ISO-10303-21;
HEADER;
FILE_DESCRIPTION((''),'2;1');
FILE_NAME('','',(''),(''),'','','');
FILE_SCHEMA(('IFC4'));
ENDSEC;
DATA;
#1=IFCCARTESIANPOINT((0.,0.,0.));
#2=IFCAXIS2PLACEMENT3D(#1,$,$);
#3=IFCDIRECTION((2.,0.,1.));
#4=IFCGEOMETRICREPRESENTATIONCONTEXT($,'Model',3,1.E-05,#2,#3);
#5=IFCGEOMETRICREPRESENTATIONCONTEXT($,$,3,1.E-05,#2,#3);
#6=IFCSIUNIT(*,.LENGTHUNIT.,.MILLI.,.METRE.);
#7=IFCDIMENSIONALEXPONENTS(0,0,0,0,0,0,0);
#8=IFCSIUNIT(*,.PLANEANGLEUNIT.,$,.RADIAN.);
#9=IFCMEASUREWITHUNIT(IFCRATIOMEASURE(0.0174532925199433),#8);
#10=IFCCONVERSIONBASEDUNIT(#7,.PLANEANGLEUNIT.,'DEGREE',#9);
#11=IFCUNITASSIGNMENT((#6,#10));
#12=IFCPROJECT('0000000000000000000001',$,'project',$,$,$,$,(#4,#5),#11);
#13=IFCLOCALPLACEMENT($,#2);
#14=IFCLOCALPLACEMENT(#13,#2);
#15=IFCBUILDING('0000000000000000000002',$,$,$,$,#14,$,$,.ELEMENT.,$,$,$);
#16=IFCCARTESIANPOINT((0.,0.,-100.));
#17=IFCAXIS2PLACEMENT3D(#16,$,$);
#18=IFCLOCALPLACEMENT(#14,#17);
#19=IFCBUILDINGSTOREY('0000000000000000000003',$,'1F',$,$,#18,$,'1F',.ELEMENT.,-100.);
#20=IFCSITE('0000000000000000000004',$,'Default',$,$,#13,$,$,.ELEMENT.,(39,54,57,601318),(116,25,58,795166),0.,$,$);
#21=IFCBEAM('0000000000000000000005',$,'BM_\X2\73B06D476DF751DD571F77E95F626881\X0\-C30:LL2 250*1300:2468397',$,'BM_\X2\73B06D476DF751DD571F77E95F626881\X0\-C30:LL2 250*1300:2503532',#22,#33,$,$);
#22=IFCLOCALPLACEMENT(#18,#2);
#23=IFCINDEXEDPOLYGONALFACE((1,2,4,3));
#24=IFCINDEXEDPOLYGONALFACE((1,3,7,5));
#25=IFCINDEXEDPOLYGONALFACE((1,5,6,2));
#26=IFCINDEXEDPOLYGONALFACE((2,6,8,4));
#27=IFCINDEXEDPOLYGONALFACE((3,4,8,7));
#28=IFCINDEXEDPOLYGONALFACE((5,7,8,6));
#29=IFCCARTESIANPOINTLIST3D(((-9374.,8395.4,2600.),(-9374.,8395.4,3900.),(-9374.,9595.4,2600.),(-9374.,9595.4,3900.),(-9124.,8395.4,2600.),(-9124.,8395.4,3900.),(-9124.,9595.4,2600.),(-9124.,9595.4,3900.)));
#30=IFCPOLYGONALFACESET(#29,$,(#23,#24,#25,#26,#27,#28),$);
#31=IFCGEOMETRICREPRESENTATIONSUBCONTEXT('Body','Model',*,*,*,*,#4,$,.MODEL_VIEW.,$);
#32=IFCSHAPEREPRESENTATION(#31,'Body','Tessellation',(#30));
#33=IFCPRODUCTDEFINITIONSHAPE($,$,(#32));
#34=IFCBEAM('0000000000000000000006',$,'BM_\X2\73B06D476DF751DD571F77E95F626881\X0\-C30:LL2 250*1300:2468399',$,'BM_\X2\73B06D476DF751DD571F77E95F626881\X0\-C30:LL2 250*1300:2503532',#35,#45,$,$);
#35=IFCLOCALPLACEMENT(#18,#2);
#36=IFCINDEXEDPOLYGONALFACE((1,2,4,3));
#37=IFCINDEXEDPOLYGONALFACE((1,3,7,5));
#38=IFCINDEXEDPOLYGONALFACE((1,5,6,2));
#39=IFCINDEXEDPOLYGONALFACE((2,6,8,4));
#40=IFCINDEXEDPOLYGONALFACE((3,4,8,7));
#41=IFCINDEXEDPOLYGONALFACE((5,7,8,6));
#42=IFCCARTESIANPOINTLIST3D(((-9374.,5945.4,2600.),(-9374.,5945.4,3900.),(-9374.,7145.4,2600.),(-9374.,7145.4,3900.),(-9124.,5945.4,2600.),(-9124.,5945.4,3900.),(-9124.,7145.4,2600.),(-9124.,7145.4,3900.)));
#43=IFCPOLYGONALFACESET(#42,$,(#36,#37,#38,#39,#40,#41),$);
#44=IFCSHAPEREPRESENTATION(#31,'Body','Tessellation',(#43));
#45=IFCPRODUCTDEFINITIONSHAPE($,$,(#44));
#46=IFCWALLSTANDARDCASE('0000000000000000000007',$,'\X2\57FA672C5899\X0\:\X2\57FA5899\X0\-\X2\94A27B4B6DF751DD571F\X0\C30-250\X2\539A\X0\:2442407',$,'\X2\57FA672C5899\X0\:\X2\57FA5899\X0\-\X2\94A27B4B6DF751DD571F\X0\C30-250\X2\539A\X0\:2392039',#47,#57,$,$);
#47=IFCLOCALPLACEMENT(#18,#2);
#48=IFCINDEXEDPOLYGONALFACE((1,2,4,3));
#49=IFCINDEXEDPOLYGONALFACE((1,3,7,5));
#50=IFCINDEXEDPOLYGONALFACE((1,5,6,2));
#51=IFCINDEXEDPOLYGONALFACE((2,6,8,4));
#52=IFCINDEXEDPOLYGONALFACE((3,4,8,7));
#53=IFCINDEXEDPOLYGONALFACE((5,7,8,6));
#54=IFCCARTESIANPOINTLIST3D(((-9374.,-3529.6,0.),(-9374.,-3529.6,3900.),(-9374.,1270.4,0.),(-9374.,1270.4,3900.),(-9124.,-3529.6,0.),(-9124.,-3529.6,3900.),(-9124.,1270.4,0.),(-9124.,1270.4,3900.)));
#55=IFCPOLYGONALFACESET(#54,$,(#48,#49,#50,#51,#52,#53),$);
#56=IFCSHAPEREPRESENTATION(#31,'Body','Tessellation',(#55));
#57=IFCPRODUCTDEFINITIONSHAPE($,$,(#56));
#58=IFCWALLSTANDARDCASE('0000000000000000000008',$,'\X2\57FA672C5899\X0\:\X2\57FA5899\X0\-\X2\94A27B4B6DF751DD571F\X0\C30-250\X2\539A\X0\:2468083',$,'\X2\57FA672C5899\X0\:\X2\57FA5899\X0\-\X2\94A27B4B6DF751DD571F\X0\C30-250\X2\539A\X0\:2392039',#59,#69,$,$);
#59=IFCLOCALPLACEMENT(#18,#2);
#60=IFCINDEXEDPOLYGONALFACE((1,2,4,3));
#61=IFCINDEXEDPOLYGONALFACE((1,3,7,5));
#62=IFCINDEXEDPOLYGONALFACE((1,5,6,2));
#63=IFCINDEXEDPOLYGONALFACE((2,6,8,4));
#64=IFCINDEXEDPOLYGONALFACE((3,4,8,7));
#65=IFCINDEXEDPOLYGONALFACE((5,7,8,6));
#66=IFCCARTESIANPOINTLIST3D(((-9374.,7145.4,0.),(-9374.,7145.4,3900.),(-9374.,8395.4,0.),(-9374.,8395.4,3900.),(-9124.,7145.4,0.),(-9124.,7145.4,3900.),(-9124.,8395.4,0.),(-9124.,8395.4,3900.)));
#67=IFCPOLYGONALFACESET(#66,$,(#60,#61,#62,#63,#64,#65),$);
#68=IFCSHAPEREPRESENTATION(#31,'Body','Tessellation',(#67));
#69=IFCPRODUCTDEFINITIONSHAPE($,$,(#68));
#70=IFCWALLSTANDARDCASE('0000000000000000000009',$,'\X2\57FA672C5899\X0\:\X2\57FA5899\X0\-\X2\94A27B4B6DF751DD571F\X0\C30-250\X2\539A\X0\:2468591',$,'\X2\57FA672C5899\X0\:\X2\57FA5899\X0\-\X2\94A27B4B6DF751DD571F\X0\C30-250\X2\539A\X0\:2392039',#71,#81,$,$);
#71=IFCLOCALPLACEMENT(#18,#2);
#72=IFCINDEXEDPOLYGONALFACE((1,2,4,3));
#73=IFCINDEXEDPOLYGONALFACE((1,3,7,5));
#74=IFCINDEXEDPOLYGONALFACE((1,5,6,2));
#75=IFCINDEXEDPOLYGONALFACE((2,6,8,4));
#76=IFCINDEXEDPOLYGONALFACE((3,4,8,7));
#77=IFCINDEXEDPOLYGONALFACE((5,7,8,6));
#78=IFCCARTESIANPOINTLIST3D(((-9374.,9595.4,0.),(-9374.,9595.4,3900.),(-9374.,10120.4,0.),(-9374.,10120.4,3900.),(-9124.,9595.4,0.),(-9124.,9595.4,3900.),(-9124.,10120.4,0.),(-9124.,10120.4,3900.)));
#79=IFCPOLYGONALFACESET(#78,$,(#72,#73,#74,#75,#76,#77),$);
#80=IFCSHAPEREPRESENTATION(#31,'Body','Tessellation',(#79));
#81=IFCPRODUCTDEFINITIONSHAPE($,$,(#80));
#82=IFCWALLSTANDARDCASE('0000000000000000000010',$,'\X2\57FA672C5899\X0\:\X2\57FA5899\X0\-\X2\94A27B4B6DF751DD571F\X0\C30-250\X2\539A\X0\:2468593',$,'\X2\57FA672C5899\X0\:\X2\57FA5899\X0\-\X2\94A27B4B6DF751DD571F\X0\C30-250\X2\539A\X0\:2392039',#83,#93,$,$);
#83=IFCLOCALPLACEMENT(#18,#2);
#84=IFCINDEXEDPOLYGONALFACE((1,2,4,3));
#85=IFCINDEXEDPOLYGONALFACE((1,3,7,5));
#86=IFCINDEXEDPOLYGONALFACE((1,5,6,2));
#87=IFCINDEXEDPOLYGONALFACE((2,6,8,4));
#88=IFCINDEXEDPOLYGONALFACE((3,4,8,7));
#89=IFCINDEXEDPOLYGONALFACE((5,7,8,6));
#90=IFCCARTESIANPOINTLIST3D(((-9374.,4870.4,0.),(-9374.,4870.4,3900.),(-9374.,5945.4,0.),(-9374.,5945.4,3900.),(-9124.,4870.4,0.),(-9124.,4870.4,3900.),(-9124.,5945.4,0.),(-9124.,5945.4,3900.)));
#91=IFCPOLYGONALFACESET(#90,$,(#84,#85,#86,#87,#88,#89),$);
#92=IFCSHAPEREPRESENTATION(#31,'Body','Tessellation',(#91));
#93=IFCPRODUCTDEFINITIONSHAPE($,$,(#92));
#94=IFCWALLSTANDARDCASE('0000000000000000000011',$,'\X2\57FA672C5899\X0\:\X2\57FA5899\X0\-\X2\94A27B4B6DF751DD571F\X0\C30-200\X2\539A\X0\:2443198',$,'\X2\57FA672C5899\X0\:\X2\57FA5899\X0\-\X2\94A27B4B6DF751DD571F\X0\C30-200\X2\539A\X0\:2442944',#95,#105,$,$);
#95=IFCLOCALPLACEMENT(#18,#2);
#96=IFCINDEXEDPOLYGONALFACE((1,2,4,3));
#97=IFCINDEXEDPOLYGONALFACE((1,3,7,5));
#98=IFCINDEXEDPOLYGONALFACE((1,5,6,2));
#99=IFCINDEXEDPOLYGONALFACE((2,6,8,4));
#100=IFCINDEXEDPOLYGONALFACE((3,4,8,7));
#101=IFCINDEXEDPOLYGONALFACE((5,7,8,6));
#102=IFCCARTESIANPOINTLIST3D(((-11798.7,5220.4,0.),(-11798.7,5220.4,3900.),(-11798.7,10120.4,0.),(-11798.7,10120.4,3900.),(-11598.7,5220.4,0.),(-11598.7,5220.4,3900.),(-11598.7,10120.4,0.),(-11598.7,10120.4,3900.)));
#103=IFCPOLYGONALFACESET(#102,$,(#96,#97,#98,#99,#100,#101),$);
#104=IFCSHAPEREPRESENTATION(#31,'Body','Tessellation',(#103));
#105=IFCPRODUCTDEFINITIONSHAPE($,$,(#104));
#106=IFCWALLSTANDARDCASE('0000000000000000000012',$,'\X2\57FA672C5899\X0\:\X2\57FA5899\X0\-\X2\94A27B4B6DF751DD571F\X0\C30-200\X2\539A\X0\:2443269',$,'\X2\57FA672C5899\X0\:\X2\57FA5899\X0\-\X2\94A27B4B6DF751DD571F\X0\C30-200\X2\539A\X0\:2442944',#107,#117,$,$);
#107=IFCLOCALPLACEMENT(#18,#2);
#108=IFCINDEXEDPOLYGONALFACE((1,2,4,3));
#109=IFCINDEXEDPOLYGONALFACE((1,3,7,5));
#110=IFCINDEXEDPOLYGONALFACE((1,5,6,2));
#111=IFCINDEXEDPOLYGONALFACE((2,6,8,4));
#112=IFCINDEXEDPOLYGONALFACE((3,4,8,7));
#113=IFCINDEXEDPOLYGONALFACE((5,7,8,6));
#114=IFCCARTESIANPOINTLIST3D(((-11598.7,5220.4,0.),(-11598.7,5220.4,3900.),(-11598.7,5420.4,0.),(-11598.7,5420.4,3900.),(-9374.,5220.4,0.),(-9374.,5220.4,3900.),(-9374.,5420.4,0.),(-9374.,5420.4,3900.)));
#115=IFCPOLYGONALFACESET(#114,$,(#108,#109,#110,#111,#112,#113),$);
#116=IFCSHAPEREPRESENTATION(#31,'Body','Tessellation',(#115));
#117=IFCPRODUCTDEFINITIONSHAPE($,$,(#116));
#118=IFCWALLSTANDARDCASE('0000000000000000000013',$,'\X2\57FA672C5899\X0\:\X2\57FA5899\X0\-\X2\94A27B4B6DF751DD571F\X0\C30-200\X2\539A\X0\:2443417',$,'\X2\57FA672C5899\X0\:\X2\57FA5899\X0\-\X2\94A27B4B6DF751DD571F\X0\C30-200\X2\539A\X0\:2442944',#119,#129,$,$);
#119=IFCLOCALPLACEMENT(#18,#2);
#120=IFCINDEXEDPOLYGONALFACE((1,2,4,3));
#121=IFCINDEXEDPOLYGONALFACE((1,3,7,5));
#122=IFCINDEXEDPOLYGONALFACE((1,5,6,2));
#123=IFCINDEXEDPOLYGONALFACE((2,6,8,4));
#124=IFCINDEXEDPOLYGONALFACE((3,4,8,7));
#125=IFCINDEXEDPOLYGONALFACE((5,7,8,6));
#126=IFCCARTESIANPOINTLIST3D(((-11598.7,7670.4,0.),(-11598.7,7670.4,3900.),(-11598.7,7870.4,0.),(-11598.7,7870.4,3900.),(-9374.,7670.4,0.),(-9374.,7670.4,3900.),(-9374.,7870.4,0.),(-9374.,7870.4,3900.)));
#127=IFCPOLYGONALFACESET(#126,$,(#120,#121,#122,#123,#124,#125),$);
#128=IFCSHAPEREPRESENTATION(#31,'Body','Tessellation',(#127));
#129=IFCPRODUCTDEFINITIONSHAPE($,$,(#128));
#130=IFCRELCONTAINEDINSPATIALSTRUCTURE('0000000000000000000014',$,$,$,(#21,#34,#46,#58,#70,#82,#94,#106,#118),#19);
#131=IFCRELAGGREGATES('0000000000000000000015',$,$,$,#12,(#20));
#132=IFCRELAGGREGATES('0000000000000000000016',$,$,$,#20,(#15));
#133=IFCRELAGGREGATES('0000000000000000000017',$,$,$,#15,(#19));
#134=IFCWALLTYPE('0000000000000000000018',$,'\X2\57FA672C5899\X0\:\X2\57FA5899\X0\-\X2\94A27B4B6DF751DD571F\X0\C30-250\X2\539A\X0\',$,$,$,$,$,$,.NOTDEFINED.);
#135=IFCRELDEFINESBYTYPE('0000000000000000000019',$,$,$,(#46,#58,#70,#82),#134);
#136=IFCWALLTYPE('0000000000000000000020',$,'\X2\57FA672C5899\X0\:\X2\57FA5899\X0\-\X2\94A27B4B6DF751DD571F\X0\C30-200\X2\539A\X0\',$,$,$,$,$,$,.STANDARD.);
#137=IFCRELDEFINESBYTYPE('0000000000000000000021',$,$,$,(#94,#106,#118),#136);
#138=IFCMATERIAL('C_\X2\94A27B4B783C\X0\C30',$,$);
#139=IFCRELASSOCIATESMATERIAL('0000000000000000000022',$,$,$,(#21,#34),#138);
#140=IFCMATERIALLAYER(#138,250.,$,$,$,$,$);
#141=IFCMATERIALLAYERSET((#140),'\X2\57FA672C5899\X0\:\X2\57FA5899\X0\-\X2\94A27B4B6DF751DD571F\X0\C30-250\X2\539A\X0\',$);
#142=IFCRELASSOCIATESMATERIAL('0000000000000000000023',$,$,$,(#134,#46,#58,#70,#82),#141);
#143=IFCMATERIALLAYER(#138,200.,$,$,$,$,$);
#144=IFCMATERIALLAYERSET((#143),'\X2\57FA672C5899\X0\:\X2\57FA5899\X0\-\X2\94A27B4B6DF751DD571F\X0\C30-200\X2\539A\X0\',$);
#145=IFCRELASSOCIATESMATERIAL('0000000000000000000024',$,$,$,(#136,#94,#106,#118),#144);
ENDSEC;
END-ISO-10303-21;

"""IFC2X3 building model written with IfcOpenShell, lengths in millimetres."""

from ifc_helpers import new_model, entity, si_unit, converted_unit, direction, frame, frame_2d, origin, place, context, subcontext, project, spatial, polyline, rectangle, extrude, clip, bounded_halfspace, material, layer, layer_set, layer_usage, type_object, element, save


model = new_model("IFC2X3")

# Units and contexts
model_context = context("Model", 3, precision=1e-05, world=origin(), true_north=direction((2.0, 0.0, 1.0)))
context_of_model = context(None, 3, precision=1e-05, world=origin(), true_north=direction((2.0, 0.0, 1.0)))
body_context = subcontext(model_context, "Body", "Model", "MODEL_VIEW")
ifc_project = project(units=[si_unit("LENGTHUNIT", "METRE", prefix="MILLI"), converted_unit("PLANEANGLEUNIT", "DEGREE", entity("IfcRatioMeasure", 0.0174532925199433), si_unit("PLANEANGLEUNIT", "RADIAN"), dimensions=[0, 0, 0, 0, 0, 0, 0])], contexts=[model_context, context_of_model])

# Site, building, storey
site_placement = place(None, origin())
site = spatial("IfcSite", under=ifc_project, at=site_placement, Name="Default", CompositionType="ELEMENT", RefLatitude=(39, 54, 57, 601318), RefLongitude=(116, 25, 58, 795166), RefElevation=0.0)
building_placement = place(site_placement, origin())
building = spatial("IfcBuilding", under=site, at=building_placement, CompositionType="ELEMENT")
storey_placement = place(building_placement, frame((0.0, 0.0, -100.0)))
storey = spatial("IfcBuildingStorey", under=building, at=storey_placement, Name="1F", LongName="1F", CompositionType="ELEMENT", Elevation=-100.0)

# Beams
ifc_material = material(Name="C_钢筋砼C30")
for number, where, z_axis, x_axis, name in (
    (1, (-9249.0, 9795.4, 3900.0), (0.0, 0.0, 1.0), (0.0, -1.0, 0.0), "BM_现浇混凝土矩形梁-C30:LL2 250*1300:2468397"),
    (2, (-9249.0, 7345.4, 3900.0), (0.0, 0.0, 1.0), (0.0, -1.0, 0.0), "BM_现浇混凝土矩形梁-C30:LL2 250*1300:2468399"),
):
    element("IfcBeam", number, at=place(storey_placement, frame(where, z_axis=z_axis, x_axis=x_axis)), inside=storey, material=ifc_material, Name=name, ObjectType="BM_现浇混凝土矩形梁-C30:LL2 250*1300:2503532", context=body_context, shape_type="SweptSolid", body=[
        extrude(rectangle(XDim=1300.0, YDim=250.0, at=frame_2d((0.0, 0.0), x_axis=(1.0, 0.0))), frame((200.0, 0.0, -650.0), z_axis=(1.0, 0.0, 0.0), x_axis=(0.0, 0.0, -1.0)), (0.0, 0.0, 1.0), 1200.0),
    ])

# Walls
ifc_layer_1 = layer(ifc_material, 250.0)
ifc_layer_set_1 = layer_set([ifc_layer_1], Name="基本墙:基墙-钢筋混凝土C30-250厚")
wall_type_1 = type_object("IfcWallType", Name="基本墙:基墙-钢筋混凝土C30-250厚", PredefinedType="NOTDEFINED", material=ifc_layer_set_1)
ifc_layer_usage_1 = layer_usage(ifc_layer_set_1, "AXIS2", "NEGATIVE", 125.0)
wall_1_placement = place(storey_placement, frame((-9249.0, 1270.4, 0.0), z_axis=(0.0, 0.0, 1.0), x_axis=(0.0, -1.0, 0.0)))
element("IfcWallStandardCase", 3, at=wall_1_placement, inside=storey, type_object=wall_type_1, material=ifc_layer_usage_1, Name="基本墙:基墙-钢筋混凝土C30-250厚:2442407", ObjectType="基本墙:基墙-钢筋混凝土C30-250厚:2392039", context=body_context, shape_type="Clipping", body=[
    clip(clip(extrude(rectangle(XDim=4800.0, YDim=250.0, at=frame_2d((2400.0, 0.0), x_axis=(-1.0, 0.0))), origin(), (0.0, 0.0, 1.0), 3900.0), bounded_halfspace(frame((4800.0, -125.0, 3900.0), z_axis=(-1.0, 0.0, 0.0), x_axis=(0.0, 0.0, -1.0)), True, frame((4800.0, -125.0, 3900.0), z_axis=(-1.0, 0.0, 0.0), x_axis=(0.0, 0.0, -1.0)), polyline([(0.0, 0.0), (0.0, -250.0), (3900.0, -250.0), (3900.0, 0.0), (0.0, 0.0)]))), bounded_halfspace(frame((0.0, -125.0, 0.0), z_axis=(-1.0, 0.0, 0.0), x_axis=(0.0, 0.0, -1.0)), False, frame((0.0, -125.0, 0.0), z_axis=(-1.0, 0.0, 0.0), x_axis=(0.0, 0.0, -1.0)), polyline([(0.0, 0.0), (-3900.0, 0.0), (-3900.0, -250.0), (0.0, -250.0), (0.0, 0.0)]))),
])
ifc_layer_usage_2 = layer_usage(ifc_layer_set_1, "AXIS2", "NEGATIVE", 125.0)
wall_2_placement = place(storey_placement, frame((-9249.0, 8395.4, 0.0), z_axis=(0.0, 0.0, 1.0), x_axis=(0.0, -1.0, 0.0)))
element("IfcWallStandardCase", 4, at=wall_2_placement, inside=storey, type_object=wall_type_1, material=ifc_layer_usage_2, Name="基本墙:基墙-钢筋混凝土C30-250厚:2468083", ObjectType="基本墙:基墙-钢筋混凝土C30-250厚:2392039", context=body_context, shape_type="SweptSolid", body=[
    extrude(rectangle(XDim=1250.0, YDim=250.0, at=frame_2d((625.0, 0.0), x_axis=(-1.0, 0.0))), origin(), (0.0, 0.0, 1.0), 3900.0),
])
ifc_layer_usage_3 = layer_usage(ifc_layer_set_1, "AXIS2", "NEGATIVE", 125.0)
wall_3_placement = place(storey_placement, frame((-9249.0, 10120.4, 0.0), z_axis=(0.0, 0.0, 1.0), x_axis=(0.0, -1.0, 0.0)))
element("IfcWallStandardCase", 5, at=wall_3_placement, inside=storey, type_object=wall_type_1, material=ifc_layer_usage_3, Name="基本墙:基墙-钢筋混凝土C30-250厚:2468591", ObjectType="基本墙:基墙-钢筋混凝土C30-250厚:2392039", context=body_context, shape_type="SweptSolid", body=[
    extrude(rectangle(XDim=525.0, YDim=250.0, at=frame_2d((262.5, 0.0), x_axis=(-1.0, 0.0))), origin(), (0.0, 0.0, 1.0), 3900.0),
])
ifc_layer_usage_4 = layer_usage(ifc_layer_set_1, "AXIS2", "NEGATIVE", 125.0)
wall_4_placement = place(storey_placement, frame((-9249.0, 5945.4, 0.0), z_axis=(0.0, 0.0, 1.0), x_axis=(0.0, -1.0, 0.0)))
element("IfcWallStandardCase", 6, at=wall_4_placement, inside=storey, type_object=wall_type_1, material=ifc_layer_usage_4, Name="基本墙:基墙-钢筋混凝土C30-250厚:2468593", ObjectType="基本墙:基墙-钢筋混凝土C30-250厚:2392039", context=body_context, shape_type="Clipping", body=[
    clip(extrude(rectangle(XDim=1075.0, YDim=250.0, at=frame_2d((537.5, 0.0), x_axis=(-1.0, 0.0))), origin(), (0.0, 0.0, 1.0), 3900.0), bounded_halfspace(frame((1075.0, -125.0, 3900.0), z_axis=(-1.0, 0.0, 0.0), x_axis=(0.0, 0.0, -1.0)), True, frame((1075.0, -125.0, 3900.0), z_axis=(-1.0, 0.0, 0.0), x_axis=(0.0, 0.0, -1.0)), polyline([(0.0, 0.0), (0.0, -250.0), (120.0, -250.0), (3900.0, -250.0), (3900.0, 0.0), (120.0, 0.0), (0.0, 0.0)]))),
])
ifc_layer_2 = layer(ifc_material, 200.0)
ifc_layer_set_2 = layer_set([ifc_layer_2], Name="基本墙:基墙-钢筋混凝土C30-200厚")
ifc_layer_usage_5 = layer_usage(ifc_layer_set_2, "AXIS2", "POSITIVE", -100.0)
wall_type_2 = type_object("IfcWallType", Name="基本墙:基墙-钢筋混凝土C30-200厚", PredefinedType="STANDARD", material=ifc_layer_set_2)
wall_5_placement = place(storey_placement, frame((-11698.7, 10120.4, 0.0), z_axis=(0.0, 0.0, 1.0), x_axis=(0.0, -1.0, 0.0)))
element("IfcWallStandardCase", 7, at=wall_5_placement, inside=storey, type_object=wall_type_2, material=ifc_layer_usage_5, Name="基本墙:基墙-钢筋混凝土C30-200厚:2443198", ObjectType="基本墙:基墙-钢筋混凝土C30-200厚:2442944", context=body_context, shape_type="SweptSolid", body=[
    extrude(rectangle(XDim=4900.0, YDim=200.0, at=frame_2d((2450.0, 0.0), x_axis=(-1.0, 0.0))), origin(), (0.0, 0.0, 1.0), 3900.0),
])
ifc_layer_usage_6 = layer_usage(ifc_layer_set_2, "AXIS2", "POSITIVE", -100.0)
wall_6_placement = place(storey_placement, frame((-11598.7, 5320.4, 0.0)))
element("IfcWallStandardCase", 8, at=wall_6_placement, inside=storey, type_object=wall_type_2, material=ifc_layer_usage_6, Name="基本墙:基墙-钢筋混凝土C30-200厚:2443269", ObjectType="基本墙:基墙-钢筋混凝土C30-200厚:2442944", context=body_context, shape_type="SweptSolid", body=[
    extrude(rectangle(XDim=2224.6, YDim=200.0, at=frame_2d((1112.3, 0.0), x_axis=(-1.0, 0.0))), origin(), (0.0, 0.0, 1.0), 3900.0),
])
ifc_layer_usage_7 = layer_usage(ifc_layer_set_2, "AXIS2", "POSITIVE", -100.0)
wall_7_placement = place(storey_placement, frame((-11598.7, 7770.4, 0.0)))
element("IfcWallStandardCase", 9, at=wall_7_placement, inside=storey, type_object=wall_type_2, material=ifc_layer_usage_7, Name="基本墙:基墙-钢筋混凝土C30-200厚:2443417", ObjectType="基本墙:基墙-钢筋混凝土C30-200厚:2442944", context=body_context, shape_type="SweptSolid", body=[
    extrude(rectangle(XDim=2224.6, YDim=200.0, at=frame_2d((1112.3, 0.0), x_axis=(-1.0, 0.0))), origin(), (0.0, 0.0, 1.0), 3900.0),
])

save(model, "model.ifc")
